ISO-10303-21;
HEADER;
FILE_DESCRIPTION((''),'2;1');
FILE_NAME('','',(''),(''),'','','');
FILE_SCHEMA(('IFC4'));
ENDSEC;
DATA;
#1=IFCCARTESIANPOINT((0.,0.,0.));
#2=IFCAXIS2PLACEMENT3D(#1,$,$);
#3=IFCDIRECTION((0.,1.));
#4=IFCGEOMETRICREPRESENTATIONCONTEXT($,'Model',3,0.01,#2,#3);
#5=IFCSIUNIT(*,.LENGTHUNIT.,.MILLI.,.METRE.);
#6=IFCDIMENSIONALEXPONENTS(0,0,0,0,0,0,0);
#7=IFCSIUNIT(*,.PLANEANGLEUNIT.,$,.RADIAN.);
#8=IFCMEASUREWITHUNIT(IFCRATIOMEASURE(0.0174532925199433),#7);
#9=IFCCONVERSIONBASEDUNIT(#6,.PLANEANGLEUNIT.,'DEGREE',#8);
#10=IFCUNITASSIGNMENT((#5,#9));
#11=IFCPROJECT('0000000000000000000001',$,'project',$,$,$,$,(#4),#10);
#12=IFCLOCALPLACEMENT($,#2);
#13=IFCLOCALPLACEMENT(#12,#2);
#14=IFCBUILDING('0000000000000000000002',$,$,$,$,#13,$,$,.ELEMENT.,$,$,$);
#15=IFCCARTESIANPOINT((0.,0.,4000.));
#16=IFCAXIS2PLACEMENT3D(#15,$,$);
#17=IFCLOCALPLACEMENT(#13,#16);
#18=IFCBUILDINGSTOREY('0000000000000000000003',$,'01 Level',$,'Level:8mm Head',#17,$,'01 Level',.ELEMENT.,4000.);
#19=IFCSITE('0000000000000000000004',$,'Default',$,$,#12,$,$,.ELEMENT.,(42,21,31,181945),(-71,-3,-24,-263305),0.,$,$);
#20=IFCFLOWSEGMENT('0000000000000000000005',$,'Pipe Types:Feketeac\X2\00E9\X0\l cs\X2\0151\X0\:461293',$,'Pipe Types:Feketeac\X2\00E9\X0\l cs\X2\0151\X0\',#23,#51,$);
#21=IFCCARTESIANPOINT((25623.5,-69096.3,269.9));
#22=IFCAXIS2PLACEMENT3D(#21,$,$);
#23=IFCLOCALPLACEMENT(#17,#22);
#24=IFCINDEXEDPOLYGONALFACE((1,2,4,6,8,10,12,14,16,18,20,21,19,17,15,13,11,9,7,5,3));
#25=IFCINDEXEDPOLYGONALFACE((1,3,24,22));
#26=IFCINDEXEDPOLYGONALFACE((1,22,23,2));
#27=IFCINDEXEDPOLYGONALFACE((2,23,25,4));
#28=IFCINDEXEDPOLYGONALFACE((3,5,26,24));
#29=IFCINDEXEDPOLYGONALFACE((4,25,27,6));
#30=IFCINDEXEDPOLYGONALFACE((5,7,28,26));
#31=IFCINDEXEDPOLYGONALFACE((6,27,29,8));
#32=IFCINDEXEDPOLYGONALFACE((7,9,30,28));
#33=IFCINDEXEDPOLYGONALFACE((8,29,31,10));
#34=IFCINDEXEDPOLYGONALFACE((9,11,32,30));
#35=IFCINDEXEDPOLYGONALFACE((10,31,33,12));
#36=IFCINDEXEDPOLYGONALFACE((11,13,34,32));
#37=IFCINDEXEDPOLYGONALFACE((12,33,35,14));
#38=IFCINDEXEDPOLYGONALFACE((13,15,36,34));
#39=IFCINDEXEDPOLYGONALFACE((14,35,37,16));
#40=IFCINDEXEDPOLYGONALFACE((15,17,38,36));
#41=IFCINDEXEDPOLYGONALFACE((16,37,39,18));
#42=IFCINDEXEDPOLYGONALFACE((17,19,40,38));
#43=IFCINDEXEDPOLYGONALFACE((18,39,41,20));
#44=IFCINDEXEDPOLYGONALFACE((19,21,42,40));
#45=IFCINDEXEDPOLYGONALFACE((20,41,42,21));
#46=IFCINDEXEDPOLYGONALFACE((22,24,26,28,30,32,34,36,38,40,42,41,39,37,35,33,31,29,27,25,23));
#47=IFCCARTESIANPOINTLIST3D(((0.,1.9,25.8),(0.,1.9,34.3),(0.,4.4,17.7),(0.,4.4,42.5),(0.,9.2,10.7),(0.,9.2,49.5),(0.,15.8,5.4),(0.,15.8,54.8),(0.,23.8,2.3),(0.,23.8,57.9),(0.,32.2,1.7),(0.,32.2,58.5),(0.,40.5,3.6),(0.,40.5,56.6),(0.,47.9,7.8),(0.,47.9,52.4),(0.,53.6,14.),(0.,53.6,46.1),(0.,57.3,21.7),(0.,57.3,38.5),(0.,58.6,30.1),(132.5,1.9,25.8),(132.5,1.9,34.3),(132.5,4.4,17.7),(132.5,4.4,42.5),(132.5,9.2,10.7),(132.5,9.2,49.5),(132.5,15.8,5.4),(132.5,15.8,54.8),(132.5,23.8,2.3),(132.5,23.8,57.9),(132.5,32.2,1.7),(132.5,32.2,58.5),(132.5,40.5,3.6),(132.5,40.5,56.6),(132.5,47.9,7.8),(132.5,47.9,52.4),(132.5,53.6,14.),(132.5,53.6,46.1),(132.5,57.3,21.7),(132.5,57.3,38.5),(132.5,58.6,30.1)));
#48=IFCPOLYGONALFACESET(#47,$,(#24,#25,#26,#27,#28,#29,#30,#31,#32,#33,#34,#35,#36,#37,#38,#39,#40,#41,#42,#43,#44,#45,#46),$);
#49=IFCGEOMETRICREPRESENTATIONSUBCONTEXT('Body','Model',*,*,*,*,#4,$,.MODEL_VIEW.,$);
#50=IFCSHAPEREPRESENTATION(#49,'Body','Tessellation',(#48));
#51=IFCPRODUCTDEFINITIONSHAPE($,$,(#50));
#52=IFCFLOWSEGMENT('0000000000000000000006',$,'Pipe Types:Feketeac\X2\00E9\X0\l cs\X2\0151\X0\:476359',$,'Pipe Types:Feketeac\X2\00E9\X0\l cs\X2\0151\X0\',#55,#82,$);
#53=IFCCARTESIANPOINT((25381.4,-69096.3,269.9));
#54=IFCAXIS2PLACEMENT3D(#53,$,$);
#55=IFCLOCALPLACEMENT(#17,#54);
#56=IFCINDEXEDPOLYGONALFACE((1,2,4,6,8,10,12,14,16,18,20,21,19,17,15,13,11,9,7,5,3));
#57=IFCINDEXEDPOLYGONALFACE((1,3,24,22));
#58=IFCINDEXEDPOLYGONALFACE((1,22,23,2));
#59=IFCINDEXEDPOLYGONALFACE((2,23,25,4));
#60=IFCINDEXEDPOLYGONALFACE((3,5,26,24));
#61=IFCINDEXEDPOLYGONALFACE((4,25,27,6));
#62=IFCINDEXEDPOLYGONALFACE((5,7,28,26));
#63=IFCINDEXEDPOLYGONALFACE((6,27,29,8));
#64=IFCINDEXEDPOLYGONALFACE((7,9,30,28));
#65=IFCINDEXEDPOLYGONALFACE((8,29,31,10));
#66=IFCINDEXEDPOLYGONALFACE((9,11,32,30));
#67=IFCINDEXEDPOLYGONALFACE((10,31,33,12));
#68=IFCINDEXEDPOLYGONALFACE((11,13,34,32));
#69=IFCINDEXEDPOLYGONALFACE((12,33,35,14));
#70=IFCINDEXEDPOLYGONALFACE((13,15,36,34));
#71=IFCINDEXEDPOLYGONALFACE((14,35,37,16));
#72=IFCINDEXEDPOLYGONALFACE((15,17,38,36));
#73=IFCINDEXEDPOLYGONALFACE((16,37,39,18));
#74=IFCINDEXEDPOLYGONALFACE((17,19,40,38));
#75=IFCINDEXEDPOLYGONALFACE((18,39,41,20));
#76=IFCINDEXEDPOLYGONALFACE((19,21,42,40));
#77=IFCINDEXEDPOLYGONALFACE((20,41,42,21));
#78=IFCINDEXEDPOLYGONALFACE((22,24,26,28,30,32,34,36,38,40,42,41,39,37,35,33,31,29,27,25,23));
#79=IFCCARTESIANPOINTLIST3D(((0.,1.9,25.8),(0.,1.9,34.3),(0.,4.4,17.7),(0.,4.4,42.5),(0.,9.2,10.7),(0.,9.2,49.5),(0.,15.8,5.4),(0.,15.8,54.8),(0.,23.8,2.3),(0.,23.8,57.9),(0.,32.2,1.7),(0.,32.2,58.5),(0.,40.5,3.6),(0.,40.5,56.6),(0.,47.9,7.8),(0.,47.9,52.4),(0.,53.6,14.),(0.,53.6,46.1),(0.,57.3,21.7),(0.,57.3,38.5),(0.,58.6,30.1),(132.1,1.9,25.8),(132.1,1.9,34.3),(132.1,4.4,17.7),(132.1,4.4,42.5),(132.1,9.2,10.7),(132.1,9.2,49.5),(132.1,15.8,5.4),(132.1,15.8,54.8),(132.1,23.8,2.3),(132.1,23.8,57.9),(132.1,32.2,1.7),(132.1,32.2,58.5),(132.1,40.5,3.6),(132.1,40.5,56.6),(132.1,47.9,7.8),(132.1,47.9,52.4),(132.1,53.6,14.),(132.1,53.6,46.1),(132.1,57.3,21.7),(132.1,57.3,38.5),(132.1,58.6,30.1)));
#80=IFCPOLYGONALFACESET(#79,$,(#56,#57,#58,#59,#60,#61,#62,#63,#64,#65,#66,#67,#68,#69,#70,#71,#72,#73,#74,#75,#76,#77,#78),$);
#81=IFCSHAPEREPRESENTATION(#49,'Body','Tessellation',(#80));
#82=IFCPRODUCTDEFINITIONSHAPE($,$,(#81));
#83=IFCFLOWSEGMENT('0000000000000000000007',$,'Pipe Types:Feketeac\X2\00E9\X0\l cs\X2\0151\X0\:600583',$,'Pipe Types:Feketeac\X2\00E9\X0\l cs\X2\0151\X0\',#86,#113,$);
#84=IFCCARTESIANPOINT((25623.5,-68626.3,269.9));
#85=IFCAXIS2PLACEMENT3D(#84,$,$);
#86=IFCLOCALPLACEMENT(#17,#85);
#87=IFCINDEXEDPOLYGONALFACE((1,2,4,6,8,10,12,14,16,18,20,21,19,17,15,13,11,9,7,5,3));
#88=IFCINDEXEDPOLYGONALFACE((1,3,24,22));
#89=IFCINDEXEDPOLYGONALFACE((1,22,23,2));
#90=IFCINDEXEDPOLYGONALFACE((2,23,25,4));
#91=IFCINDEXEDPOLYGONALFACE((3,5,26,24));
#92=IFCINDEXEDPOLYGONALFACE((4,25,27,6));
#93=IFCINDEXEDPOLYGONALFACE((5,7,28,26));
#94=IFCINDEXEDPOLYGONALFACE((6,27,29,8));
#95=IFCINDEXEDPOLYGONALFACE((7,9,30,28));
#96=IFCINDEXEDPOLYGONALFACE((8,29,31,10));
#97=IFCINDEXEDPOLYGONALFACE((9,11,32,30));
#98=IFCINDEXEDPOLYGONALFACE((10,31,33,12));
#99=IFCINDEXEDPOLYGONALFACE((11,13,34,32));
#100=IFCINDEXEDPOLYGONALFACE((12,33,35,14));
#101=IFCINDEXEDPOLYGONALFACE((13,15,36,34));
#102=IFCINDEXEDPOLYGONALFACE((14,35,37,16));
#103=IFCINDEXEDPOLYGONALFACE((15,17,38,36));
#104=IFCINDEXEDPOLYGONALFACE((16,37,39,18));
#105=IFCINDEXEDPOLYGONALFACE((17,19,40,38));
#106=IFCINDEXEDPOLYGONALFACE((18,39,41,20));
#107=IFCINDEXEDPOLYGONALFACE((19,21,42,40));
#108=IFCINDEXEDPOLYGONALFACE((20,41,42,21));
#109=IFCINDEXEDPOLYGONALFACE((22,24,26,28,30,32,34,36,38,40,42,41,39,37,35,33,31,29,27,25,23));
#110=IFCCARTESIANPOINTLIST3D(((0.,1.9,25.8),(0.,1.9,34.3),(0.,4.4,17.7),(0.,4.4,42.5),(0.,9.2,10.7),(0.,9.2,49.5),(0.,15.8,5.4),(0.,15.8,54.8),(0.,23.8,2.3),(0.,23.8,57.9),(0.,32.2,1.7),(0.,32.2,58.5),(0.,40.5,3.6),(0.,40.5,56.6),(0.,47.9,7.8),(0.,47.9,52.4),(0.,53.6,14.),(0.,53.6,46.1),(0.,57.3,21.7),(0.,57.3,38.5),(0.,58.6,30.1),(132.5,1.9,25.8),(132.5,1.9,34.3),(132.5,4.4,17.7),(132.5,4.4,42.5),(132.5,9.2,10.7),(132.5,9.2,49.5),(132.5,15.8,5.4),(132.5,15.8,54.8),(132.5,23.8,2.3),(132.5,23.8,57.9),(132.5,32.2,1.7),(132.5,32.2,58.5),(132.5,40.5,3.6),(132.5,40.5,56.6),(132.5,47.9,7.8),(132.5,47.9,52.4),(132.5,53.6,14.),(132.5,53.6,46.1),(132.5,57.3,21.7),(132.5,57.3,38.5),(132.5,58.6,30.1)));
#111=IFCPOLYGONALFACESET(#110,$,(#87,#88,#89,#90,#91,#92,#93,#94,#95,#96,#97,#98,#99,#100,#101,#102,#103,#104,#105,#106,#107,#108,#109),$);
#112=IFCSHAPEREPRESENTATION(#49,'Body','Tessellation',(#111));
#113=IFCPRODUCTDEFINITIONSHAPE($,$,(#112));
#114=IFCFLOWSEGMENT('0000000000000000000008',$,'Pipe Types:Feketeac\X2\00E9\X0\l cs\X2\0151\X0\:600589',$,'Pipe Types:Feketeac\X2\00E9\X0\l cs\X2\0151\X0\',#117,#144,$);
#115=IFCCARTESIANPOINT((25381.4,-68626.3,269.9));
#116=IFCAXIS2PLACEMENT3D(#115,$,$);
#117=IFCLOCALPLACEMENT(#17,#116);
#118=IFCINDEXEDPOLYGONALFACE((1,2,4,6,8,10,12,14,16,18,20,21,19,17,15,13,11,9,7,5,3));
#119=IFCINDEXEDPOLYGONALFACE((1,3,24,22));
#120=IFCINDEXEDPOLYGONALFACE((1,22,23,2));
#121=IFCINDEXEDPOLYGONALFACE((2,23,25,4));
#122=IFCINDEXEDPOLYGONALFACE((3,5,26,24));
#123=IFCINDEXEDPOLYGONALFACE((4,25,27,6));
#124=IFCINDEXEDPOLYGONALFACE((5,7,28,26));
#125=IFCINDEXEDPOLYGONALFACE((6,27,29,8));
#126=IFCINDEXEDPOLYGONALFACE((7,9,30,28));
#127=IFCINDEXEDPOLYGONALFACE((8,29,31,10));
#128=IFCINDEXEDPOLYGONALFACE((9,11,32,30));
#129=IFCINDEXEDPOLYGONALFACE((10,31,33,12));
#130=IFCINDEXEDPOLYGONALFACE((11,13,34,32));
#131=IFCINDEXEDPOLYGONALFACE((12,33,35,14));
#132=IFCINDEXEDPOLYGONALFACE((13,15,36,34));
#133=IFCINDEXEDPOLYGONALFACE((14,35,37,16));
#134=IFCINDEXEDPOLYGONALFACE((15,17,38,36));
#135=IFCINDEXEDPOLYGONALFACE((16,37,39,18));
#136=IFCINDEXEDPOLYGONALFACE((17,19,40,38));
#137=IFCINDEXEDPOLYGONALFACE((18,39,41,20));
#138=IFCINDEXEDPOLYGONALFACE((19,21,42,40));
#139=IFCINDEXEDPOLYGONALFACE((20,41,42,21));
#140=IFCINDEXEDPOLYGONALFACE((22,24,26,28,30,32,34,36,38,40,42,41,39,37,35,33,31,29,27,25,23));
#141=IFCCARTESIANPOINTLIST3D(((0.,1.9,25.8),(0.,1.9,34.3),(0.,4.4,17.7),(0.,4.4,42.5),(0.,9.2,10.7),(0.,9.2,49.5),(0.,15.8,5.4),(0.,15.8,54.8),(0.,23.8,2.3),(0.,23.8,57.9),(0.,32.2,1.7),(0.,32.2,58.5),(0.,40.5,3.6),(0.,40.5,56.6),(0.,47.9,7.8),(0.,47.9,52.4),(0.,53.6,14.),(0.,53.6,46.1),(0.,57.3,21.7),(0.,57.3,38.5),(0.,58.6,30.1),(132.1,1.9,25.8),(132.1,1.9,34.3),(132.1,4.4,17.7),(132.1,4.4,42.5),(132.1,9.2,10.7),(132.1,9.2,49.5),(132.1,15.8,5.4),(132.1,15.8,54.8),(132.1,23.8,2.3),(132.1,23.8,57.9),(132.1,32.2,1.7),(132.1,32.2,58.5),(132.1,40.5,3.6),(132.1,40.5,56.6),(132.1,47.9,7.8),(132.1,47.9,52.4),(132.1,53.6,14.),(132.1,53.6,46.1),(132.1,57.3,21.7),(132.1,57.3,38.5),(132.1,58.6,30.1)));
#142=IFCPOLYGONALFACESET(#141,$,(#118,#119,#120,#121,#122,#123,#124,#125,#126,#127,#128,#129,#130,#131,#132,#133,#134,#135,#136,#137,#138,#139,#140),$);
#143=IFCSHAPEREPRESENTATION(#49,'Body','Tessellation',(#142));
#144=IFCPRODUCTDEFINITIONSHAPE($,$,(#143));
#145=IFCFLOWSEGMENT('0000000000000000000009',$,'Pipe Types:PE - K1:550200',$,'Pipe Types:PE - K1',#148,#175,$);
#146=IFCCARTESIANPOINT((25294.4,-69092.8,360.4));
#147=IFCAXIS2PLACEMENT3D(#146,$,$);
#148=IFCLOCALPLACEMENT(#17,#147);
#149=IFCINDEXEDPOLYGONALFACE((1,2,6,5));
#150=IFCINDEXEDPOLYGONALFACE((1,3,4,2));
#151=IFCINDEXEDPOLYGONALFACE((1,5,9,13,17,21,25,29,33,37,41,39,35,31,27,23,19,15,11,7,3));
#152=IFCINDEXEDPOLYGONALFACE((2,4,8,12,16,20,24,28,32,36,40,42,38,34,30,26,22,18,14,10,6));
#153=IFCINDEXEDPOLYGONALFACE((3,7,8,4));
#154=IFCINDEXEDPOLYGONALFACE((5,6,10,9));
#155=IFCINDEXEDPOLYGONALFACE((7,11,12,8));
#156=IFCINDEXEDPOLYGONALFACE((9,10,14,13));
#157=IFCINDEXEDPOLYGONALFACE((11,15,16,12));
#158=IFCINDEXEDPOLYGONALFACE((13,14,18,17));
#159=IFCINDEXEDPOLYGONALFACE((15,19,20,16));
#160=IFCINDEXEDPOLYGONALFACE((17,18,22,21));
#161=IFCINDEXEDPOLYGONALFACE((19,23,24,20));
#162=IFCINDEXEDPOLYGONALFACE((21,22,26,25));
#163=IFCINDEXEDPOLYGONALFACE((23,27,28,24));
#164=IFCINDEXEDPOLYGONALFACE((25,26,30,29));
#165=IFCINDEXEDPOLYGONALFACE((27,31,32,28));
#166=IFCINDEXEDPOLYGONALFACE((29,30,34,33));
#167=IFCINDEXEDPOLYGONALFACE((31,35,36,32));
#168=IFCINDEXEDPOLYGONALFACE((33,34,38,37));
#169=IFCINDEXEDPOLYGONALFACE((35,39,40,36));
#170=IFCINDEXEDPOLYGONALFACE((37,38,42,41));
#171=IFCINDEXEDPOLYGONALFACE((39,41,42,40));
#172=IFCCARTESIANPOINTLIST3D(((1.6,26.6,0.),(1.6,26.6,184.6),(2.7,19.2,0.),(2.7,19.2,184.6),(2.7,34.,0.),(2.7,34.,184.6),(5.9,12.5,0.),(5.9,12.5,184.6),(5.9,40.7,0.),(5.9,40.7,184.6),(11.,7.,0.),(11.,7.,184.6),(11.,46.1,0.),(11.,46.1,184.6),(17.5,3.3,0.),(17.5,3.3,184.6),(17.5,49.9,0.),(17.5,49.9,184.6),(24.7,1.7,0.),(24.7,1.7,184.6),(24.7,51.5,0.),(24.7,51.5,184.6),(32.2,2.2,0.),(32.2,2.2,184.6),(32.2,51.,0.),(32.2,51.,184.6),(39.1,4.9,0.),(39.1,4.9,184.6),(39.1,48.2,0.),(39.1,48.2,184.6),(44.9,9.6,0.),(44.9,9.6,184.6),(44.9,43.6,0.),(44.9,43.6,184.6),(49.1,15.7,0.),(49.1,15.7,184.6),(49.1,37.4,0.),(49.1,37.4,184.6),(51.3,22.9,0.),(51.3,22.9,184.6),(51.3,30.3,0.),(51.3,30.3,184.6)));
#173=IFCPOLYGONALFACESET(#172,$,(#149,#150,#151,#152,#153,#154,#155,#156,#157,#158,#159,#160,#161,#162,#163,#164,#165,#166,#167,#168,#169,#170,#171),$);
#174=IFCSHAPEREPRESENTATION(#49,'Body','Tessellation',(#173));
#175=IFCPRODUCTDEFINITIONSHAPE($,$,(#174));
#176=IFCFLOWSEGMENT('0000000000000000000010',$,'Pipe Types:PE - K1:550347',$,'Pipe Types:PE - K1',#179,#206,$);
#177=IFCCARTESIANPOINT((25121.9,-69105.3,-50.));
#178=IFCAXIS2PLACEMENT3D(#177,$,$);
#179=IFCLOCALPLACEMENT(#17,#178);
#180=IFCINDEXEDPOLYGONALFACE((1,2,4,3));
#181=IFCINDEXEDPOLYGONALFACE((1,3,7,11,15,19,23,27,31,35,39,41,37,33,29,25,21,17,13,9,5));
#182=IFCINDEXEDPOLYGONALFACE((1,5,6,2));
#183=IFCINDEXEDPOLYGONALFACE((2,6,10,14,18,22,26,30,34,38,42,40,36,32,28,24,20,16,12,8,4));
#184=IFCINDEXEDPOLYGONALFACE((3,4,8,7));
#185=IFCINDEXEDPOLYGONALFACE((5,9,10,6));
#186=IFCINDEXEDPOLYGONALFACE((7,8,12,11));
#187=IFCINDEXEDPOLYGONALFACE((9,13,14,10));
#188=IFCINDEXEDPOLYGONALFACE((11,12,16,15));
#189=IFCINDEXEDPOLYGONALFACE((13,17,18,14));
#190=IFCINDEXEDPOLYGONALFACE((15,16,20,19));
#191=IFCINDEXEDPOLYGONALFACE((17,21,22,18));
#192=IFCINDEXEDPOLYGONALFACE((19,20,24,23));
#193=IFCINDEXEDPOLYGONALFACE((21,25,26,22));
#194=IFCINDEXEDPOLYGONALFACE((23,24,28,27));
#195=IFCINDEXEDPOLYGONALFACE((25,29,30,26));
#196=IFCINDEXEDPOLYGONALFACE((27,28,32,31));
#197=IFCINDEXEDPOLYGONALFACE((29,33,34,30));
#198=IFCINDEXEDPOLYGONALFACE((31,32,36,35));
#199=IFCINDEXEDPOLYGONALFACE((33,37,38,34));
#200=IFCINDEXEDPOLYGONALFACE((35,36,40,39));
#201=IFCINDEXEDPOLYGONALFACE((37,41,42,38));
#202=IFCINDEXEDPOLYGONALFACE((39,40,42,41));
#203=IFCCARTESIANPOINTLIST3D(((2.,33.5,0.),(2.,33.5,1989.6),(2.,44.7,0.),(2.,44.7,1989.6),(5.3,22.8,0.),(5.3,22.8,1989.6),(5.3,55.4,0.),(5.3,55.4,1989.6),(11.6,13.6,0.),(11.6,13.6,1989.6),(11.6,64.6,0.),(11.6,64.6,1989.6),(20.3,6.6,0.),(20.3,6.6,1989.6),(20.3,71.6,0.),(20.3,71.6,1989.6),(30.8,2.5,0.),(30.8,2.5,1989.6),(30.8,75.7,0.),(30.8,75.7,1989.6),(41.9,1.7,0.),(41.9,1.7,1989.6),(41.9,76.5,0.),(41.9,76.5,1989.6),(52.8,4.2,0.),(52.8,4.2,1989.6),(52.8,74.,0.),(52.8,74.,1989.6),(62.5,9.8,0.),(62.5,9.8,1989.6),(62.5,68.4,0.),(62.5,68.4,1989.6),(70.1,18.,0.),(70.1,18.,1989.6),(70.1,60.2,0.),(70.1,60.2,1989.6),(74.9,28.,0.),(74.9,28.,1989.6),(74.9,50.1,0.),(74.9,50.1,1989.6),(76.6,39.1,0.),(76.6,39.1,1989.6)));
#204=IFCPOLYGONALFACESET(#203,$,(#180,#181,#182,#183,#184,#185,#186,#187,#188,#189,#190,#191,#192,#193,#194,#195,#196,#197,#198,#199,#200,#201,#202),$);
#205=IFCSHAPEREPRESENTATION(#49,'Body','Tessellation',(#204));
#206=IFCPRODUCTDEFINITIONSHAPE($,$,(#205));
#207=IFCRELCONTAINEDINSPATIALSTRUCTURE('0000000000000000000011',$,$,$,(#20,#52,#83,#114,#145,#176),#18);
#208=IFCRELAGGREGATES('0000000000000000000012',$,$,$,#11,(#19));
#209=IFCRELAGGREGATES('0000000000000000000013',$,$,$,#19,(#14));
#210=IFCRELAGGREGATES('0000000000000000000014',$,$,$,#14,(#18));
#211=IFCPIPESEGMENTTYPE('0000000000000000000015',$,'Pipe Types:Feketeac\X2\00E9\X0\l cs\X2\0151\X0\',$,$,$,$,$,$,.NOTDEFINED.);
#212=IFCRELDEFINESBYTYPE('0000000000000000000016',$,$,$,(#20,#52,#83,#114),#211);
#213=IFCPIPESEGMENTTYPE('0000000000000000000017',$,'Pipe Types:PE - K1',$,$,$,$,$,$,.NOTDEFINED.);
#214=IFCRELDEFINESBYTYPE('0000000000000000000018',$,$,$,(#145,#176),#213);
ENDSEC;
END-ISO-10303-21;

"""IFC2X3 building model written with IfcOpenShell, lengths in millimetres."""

from ifc_helpers import new_model, entity, si_unit, converted_unit, direction, frame, frame_2d, origin, origin_2d_with_axis, place, context, subcontext, project, spatial, circle, extrude, type_object, element, save


model = new_model("IFC2X3")

# Units and contexts
model_context = context("Model", 3, precision=0.01, world=origin(), true_north=direction((0.0, 1.0)))
body_context = subcontext(model_context, "Body", "Model", "MODEL_VIEW")
ifc_project = project(units=[si_unit("LENGTHUNIT", "METRE", prefix="MILLI"), converted_unit("PLANEANGLEUNIT", "DEGREE", entity("IfcRatioMeasure", 0.0174532925199433), si_unit("PLANEANGLEUNIT", "RADIAN"), dimensions=[0, 0, 0, 0, 0, 0, 0])], contexts=[model_context])

# Site, building, storey
site_placement = place(None, origin())
site = spatial("IfcSite", under=ifc_project, at=site_placement, Name="Default", CompositionType="ELEMENT", RefLatitude=(42, 21, 31, 181945), RefLongitude=(-71, -3, -24, -263305), RefElevation=0.0)
building_placement = place(site_placement, origin())
building = spatial("IfcBuilding", under=site, at=building_placement, CompositionType="ELEMENT")
storey_placement = place(building_placement, frame((0.0, 0.0, 4000.0)))
storey = spatial("IfcBuildingStorey", under=building, at=storey_placement, Name="01 Level", ObjectType="Level:8mm Head", LongName="01 Level", CompositionType="ELEMENT", Elevation=4000.0)

# Flow segments
pipe_segment_type_1 = type_object("IfcPipeSegmentType", Name="Pipe Types:Feketeacél cső", PredefinedType="NOTDEFINED")
flow_segment_1_placement = place(storey_placement, frame((25623.5, -69096.3, 269.9)))
element("IfcFlowSegment", 1, at=flow_segment_1_placement, inside=storey, type_object=pipe_segment_type_1, Name="Pipe Types:Feketeacél cső:461293", ObjectType="Pipe Types:Feketeacél cső", context=body_context, shape_type="SweptSolid", body=[
    extrude(circle(Radius=28.5, at=frame_2d((0.0, 0.0), x_axis=(1.0, 0.0))), frame((0.0, 30.1, 30.1), z_axis=(1.0, 0.0, 0.0), x_axis=(0.0, 1.0, 0.0)), (0.0, 0.0, 1.0), 132.5),
])
flow_segment_2_placement = place(storey_placement, frame((25381.4, -69096.3, 269.9)))
element("IfcFlowSegment", 2, at=flow_segment_2_placement, inside=storey, type_object=pipe_segment_type_1, Name="Pipe Types:Feketeacél cső:476359", ObjectType="Pipe Types:Feketeacél cső", context=body_context, shape_type="SweptSolid", body=[
    extrude(circle(Radius=28.5, at=origin_2d_with_axis()), frame((0.0, 30.1, 30.1), z_axis=(1.0, 0.0, 0.0), x_axis=(0.0, 1.0, 0.0)), (0.0, 0.0, 1.0), 132.1),
])
flow_segment_3_placement = place(storey_placement, frame((25623.5, -68626.3, 269.9)))
element("IfcFlowSegment", 3, at=flow_segment_3_placement, inside=storey, type_object=pipe_segment_type_1, Name="Pipe Types:Feketeacél cső:600583", ObjectType="Pipe Types:Feketeacél cső", context=body_context, shape_type="SweptSolid", body=[
    extrude(circle(Radius=28.5, at=frame_2d((0.0, 0.0), x_axis=(1.0, 0.0))), frame((0.0, 30.1, 30.1), z_axis=(1.0, 0.0, 0.0), x_axis=(0.0, 1.0, 0.0)), (0.0, 0.0, 1.0), 132.5),
])
flow_segment_4_placement = place(storey_placement, frame((25381.4, -68626.3, 269.9)))
element("IfcFlowSegment", 4, at=flow_segment_4_placement, inside=storey, type_object=pipe_segment_type_1, Name="Pipe Types:Feketeacél cső:600589", ObjectType="Pipe Types:Feketeacél cső", context=body_context, shape_type="SweptSolid", body=[
    extrude(circle(Radius=28.5, at=origin_2d_with_axis()), frame((0.0, 30.1, 30.1), z_axis=(1.0, 0.0, 0.0), x_axis=(0.0, 1.0, 0.0)), (0.0, 0.0, 1.0), 132.1),
])
pipe_segment_type_2 = type_object("IfcPipeSegmentType", Name="Pipe Types:PE - K1", PredefinedType="NOTDEFINED")
flow_segment_5_placement = place(storey_placement, frame((25294.4, -69092.8, 360.4)))
element("IfcFlowSegment", 5, at=flow_segment_5_placement, inside=storey, type_object=pipe_segment_type_2, Name="Pipe Types:PE - K1:550200", ObjectType="Pipe Types:PE - K1", context=body_context, shape_type="SweptSolid", body=[
    extrude(circle(Radius=25.0, at=origin_2d_with_axis()), frame((26.6, 26.6, 0.0), z_axis=(0.0, 0.0, 1.0), x_axis=(-1.0, 0.0, 0.0)), (0.0, 0.0, 1.0), 184.6),
])
flow_segment_6_placement = place(storey_placement, frame((25121.9, -69105.3, -50.0)))
element("IfcFlowSegment", 6, at=flow_segment_6_placement, inside=storey, type_object=pipe_segment_type_2, Name="Pipe Types:PE - K1:550347", ObjectType="Pipe Types:PE - K1", context=body_context, shape_type="SweptSolid", body=[
    extrude(circle(Radius=37.5, at=origin_2d_with_axis()), frame((39.1, 39.1, 0.0)), (0.0, 0.0, 1.0), 1989.6),
])

save(model, "model.ifc")
